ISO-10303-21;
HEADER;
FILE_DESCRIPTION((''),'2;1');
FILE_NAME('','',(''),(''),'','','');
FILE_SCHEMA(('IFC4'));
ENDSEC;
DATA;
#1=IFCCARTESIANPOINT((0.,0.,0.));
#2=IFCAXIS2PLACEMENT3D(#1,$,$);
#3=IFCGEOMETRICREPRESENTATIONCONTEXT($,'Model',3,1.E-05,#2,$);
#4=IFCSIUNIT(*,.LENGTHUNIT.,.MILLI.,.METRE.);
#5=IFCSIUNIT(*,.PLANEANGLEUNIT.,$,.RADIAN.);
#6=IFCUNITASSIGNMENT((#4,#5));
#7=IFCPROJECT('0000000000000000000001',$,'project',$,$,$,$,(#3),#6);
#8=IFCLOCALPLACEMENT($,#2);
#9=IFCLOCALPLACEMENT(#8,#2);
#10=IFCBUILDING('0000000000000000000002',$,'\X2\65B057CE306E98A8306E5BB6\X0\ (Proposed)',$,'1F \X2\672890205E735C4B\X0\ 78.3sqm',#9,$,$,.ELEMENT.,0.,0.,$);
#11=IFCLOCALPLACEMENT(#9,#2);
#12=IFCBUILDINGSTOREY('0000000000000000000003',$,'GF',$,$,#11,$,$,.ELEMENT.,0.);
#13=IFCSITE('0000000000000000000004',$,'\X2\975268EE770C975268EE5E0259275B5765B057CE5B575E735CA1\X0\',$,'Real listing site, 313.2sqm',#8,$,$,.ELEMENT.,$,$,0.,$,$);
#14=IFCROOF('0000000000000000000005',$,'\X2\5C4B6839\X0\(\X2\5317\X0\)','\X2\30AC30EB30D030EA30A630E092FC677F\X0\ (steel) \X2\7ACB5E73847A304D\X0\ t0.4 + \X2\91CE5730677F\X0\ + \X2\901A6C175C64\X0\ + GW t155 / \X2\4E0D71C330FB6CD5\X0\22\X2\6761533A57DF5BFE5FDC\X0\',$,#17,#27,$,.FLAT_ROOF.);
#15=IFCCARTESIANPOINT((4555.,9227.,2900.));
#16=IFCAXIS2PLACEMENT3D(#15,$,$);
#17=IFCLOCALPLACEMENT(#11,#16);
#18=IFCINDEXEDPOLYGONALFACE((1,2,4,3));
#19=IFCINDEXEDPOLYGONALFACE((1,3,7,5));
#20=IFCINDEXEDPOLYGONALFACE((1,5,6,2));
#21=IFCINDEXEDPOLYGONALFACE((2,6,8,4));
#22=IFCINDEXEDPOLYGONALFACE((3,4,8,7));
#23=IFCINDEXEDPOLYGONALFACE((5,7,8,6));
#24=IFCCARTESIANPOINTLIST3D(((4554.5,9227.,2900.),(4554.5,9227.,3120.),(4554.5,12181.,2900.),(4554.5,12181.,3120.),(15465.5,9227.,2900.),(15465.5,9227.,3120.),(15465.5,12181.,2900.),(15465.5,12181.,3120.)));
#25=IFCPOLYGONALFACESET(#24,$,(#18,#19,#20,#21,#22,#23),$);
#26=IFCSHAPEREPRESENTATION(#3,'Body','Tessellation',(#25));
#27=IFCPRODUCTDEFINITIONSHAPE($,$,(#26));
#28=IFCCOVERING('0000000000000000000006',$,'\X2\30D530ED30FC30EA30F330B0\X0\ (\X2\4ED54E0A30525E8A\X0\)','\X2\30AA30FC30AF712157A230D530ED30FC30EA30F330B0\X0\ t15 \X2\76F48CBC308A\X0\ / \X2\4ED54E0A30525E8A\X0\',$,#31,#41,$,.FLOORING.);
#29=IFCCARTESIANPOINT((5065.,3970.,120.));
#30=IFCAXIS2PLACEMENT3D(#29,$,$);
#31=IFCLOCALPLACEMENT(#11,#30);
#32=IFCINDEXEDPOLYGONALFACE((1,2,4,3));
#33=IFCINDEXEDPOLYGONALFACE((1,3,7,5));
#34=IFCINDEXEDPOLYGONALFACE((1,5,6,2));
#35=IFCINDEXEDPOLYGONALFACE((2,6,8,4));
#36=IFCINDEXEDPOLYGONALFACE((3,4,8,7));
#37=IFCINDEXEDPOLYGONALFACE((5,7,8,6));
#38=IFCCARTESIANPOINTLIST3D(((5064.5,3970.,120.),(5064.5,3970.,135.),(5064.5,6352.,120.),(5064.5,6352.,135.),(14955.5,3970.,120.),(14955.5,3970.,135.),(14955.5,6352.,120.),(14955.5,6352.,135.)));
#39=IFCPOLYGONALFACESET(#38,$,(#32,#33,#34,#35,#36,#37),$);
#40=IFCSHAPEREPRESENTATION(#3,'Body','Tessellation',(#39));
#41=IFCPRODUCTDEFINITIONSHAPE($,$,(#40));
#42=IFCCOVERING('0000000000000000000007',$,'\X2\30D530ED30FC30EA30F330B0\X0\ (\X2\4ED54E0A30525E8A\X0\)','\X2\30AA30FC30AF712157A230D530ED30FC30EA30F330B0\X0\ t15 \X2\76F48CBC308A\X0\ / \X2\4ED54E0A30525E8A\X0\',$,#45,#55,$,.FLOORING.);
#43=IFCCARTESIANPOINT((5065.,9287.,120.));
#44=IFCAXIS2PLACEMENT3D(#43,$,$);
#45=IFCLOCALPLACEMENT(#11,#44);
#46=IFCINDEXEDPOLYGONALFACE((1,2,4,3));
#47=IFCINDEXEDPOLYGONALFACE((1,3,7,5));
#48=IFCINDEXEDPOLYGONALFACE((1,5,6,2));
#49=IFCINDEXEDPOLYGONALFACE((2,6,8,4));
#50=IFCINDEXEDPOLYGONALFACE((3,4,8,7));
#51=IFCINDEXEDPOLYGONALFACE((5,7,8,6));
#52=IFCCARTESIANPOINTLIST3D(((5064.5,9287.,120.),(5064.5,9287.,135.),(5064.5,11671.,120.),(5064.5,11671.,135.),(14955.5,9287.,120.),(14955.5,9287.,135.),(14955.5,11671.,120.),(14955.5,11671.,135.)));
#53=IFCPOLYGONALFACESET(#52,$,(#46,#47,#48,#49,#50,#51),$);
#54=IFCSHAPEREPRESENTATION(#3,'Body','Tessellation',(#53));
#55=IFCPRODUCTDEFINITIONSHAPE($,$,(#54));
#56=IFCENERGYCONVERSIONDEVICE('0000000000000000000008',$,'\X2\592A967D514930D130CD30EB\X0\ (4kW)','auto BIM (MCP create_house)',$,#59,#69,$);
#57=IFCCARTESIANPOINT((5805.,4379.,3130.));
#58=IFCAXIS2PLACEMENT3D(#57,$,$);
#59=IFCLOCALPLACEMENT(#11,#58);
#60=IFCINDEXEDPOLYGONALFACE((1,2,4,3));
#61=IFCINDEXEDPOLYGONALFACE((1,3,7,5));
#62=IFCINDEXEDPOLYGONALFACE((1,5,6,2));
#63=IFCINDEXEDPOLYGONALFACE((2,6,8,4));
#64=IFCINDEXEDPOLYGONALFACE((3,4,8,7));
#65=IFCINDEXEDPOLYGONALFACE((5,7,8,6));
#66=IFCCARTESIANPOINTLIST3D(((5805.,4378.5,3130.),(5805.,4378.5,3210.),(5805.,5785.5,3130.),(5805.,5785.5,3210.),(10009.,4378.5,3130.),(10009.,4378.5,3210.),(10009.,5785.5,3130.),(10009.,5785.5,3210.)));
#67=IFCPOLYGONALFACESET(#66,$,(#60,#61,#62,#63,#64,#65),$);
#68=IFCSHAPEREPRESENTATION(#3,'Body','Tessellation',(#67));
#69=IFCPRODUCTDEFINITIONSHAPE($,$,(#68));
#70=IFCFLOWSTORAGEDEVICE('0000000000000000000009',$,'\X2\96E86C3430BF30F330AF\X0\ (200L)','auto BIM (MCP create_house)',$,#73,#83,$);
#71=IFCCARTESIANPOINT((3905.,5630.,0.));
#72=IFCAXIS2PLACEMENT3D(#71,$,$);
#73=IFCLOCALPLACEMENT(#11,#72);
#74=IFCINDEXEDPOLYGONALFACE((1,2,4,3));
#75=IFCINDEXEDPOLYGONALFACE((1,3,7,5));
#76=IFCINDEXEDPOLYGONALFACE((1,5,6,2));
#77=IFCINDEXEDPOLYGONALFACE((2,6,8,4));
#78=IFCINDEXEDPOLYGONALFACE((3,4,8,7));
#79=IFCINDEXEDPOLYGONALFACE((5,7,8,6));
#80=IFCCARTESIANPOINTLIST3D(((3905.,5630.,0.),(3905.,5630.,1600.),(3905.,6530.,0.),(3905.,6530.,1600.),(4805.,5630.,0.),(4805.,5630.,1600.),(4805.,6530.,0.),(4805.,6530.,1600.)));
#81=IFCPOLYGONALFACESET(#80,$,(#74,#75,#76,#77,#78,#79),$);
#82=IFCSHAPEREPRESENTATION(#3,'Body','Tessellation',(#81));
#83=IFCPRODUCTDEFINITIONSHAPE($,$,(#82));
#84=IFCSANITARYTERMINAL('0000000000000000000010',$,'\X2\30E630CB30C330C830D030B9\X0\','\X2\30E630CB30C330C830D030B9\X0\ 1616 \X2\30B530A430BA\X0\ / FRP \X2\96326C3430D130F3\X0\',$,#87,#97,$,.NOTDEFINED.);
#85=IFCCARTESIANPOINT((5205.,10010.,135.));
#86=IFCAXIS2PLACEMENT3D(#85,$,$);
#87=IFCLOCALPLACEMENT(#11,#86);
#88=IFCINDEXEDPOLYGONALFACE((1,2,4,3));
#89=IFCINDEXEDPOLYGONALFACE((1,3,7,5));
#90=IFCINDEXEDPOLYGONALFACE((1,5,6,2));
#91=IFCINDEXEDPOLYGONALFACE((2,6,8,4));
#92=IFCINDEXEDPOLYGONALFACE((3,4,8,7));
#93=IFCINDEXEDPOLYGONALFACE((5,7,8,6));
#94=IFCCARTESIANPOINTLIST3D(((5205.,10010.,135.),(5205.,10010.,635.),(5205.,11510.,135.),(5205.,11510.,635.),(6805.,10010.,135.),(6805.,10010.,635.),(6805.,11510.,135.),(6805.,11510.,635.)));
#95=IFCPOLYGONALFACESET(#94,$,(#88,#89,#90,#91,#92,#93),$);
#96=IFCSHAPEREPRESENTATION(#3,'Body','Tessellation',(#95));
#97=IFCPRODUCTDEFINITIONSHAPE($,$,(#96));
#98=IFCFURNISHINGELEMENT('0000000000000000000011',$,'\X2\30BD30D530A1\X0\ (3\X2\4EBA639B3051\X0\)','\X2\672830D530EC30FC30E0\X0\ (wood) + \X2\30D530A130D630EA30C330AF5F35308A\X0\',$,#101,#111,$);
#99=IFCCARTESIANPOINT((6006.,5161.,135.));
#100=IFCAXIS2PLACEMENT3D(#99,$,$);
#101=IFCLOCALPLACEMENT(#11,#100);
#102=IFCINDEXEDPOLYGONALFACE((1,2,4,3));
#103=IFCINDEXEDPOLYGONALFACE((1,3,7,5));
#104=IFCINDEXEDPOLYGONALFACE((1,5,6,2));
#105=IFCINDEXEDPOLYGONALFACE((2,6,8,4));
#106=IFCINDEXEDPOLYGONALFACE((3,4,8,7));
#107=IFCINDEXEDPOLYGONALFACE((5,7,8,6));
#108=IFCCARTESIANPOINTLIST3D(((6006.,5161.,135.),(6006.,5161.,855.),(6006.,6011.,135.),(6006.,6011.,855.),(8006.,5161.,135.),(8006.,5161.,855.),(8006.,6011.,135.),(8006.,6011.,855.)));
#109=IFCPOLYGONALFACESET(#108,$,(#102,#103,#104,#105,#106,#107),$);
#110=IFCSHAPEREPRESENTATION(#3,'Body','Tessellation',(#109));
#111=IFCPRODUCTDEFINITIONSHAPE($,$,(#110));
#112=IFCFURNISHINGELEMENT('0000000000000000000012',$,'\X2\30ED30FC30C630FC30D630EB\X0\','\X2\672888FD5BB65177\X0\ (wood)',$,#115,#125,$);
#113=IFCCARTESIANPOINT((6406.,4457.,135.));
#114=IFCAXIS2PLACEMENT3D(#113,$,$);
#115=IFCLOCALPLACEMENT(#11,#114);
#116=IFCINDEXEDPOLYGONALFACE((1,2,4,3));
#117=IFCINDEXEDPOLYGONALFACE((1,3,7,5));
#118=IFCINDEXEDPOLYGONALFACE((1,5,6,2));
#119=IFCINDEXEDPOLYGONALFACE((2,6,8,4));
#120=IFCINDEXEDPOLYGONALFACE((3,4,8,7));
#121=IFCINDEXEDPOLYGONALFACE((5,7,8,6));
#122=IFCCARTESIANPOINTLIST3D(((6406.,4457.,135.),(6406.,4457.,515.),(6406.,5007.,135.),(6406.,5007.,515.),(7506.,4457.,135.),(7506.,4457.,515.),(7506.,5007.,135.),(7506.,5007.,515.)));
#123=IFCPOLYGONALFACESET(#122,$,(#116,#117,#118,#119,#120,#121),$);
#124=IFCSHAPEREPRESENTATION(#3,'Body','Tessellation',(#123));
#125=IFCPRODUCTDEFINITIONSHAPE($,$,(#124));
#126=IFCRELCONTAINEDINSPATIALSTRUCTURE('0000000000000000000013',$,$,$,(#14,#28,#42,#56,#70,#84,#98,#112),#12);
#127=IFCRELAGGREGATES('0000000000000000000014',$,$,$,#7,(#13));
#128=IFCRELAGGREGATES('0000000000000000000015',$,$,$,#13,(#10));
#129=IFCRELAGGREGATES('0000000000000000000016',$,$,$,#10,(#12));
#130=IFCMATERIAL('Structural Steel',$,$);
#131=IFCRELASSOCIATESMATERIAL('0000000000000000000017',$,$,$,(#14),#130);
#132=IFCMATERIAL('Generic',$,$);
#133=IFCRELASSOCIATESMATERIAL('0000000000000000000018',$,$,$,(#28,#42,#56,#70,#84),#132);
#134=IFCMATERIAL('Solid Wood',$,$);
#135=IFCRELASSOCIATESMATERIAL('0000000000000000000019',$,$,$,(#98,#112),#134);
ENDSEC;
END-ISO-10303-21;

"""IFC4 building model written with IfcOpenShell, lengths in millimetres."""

from ifc_helpers import new_model, si_unit, frame, frame_2d, origin, place, context, project, spatial, rectangle, extrude, material, element, save


model = new_model("IFC4")

# Units and contexts
model_context = context("Model", 3, precision=1e-05, world=origin())
ifc_project = project(units=[si_unit("LENGTHUNIT", "METRE", prefix="MILLI"), si_unit("PLANEANGLEUNIT", "RADIAN")], contexts=[model_context])

# Site, building, storey
site_placement = place(None, origin())
site = spatial("IfcSite", under=ifc_project, at=site_placement, Name="青森県青森市大字新城字平岡", ObjectType="Real listing site, 313.2sqm", CompositionType="ELEMENT", RefElevation=0.0)
building_placement = place(site_placement, origin())
building = spatial("IfcBuilding", under=site, at=building_placement, Name="新城の風の家 (Proposed)", ObjectType="1F 木造平屋 78.3sqm", CompositionType="ELEMENT", ElevationOfRefHeight=0.0, ElevationOfTerrain=0.0)
storey_placement = place(building_placement, origin())
storey = spatial("IfcBuildingStorey", under=building, at=storey_placement, Name="GF", CompositionType="ELEMENT", Elevation=0.0)

# Shared definitions
ifc_material_1 = material(Name="Solid Wood")

# Roof
ifc_material_2 = material(Name="Structural Steel")
roof_1_placement = place(storey_placement, frame((4555.0, 9227.0, 2900.0)))
element("IfcRoof", 1, at=roof_1_placement, inside=storey, material=ifc_material_2, Name="屋根(北)", Description="ガルバリウム鋼板 (steel) 立平葺き t0.4 + 野地板 + 通気層 + GW t155 / 不燃・法22条区域対応", PredefinedType="FLAT_ROOF", context=model_context, shape_type="SweptSolid", body=[
    extrude(rectangle(XDim=10911.0, YDim=2954.0, at=frame_2d((5455.0, 1477.0))), frame((4555.0, 9227.0, 2900.0)), (0.0, 0.0, 1.0), 220.0),
])

# Coverings
ifc_material_3 = material(Name="Generic")
covering_1_placement = place(storey_placement, frame((5065.0, 3970.0, 120.0)))
element("IfcCovering", 2, at=covering_1_placement, inside=storey, material=ifc_material_3, Name="フローリング (仕上げ床)", Description="オーク無垢フローリング t15 直貼り / 仕上げ床", PredefinedType="FLOORING", context=model_context, shape_type="SweptSolid", body=[
    extrude(rectangle(XDim=9891.0, YDim=2382.0, at=frame_2d((4945.0, 1191.0))), frame((5065.0, 3970.0, 120.0)), (0.0, 0.0, 1.0), 15.0),
])
covering_2_placement = place(storey_placement, frame((5065.0, 9287.0, 120.0)))
element("IfcCovering", 3, at=covering_2_placement, inside=storey, material=ifc_material_3, Name="フローリング (仕上げ床)", Description="オーク無垢フローリング t15 直貼り / 仕上げ床", PredefinedType="FLOORING", context=model_context, shape_type="SweptSolid", body=[
    extrude(rectangle(XDim=9891.0, YDim=2384.0, at=frame_2d((4945.0, 1192.0))), frame((5065.0, 9287.0, 120.0)), (0.0, 0.0, 1.0), 15.0),
])

# Energy conversion device
energy_conversion_device_placement = place(storey_placement, frame((5805.0, 4379.0, 3130.0)))
element("IfcEnergyConversionDevice", 4, at=energy_conversion_device_placement, inside=storey, material=ifc_material_3, Name="太陽光パネル (4kW)", Description="auto BIM (MCP create_house)", context=model_context, shape_type="SweptSolid", body=[
    extrude(rectangle(XDim=4204.0, YDim=1407.0, at=frame_2d((2102.0, 703.0))), frame((5805.0, 4379.0, 3130.0)), (0.0, 0.0, 1.0), 80.0),
])

# Flow storage device
flow_storage_device_placement = place(storey_placement, frame((3905.0, 5630.0, 0.0)))
element("IfcFlowStorageDevice", 5, at=flow_storage_device_placement, inside=storey, material=ifc_material_3, Name="雨水タンク (200L)", Description="auto BIM (MCP create_house)", context=model_context, shape_type="SweptSolid", body=[
    extrude(rectangle(XDim=900.0, YDim=900.0, at=frame_2d((450.0, 450.0))), frame((3905.0, 5630.0, 0.0)), (0.0, 0.0, 1.0), 1600.0),
])

# Sanitary terminal
sanitary_terminal_placement = place(storey_placement, frame((5205.0, 10010.0, 135.0)))
element("IfcSanitaryTerminal", 6, at=sanitary_terminal_placement, inside=storey, material=ifc_material_3, Name="ユニットバス", Description="ユニットバス 1616 サイズ / FRP 防水パン", PredefinedType="NOTDEFINED", context=model_context, shape_type="SweptSolid", body=[
    extrude(rectangle(XDim=1600.0, YDim=1500.0, at=frame_2d((800.0, 750.0))), frame((5205.0, 10010.0, 135.0)), (0.0, 0.0, 1.0), 500.0),
])

# Furnishing elements
furnishing_1_placement = place(storey_placement, frame((6006.0, 5161.0, 135.0)))
element("IfcFurnishingElement", 7, at=furnishing_1_placement, inside=storey, material=ifc_material_1, Name="ソファ (3人掛け)", Description="木フレーム (wood) + ファブリック張り", context=model_context, shape_type="SweptSolid", body=[
    extrude(rectangle(XDim=2000.0, YDim=850.0, at=frame_2d((1000.0, 425.0))), frame((6006.0, 5161.0, 135.0)), (0.0, 0.0, 1.0), 720.0),
])
furnishing_2_placement = place(storey_placement, frame((6406.0, 4457.0, 135.0)))
element("IfcFurnishingElement", 8, at=furnishing_2_placement, inside=storey, material=ifc_material_1, Name="ローテーブル", Description="木製家具 (wood)", context=model_context, shape_type="SweptSolid", body=[
    extrude(rectangle(XDim=1100.0, YDim=550.0, at=frame_2d((550.0, 275.0))), frame((6406.0, 4457.0, 135.0)), (0.0, 0.0, 1.0), 380.0),
])

save(model, "model.ifc")
